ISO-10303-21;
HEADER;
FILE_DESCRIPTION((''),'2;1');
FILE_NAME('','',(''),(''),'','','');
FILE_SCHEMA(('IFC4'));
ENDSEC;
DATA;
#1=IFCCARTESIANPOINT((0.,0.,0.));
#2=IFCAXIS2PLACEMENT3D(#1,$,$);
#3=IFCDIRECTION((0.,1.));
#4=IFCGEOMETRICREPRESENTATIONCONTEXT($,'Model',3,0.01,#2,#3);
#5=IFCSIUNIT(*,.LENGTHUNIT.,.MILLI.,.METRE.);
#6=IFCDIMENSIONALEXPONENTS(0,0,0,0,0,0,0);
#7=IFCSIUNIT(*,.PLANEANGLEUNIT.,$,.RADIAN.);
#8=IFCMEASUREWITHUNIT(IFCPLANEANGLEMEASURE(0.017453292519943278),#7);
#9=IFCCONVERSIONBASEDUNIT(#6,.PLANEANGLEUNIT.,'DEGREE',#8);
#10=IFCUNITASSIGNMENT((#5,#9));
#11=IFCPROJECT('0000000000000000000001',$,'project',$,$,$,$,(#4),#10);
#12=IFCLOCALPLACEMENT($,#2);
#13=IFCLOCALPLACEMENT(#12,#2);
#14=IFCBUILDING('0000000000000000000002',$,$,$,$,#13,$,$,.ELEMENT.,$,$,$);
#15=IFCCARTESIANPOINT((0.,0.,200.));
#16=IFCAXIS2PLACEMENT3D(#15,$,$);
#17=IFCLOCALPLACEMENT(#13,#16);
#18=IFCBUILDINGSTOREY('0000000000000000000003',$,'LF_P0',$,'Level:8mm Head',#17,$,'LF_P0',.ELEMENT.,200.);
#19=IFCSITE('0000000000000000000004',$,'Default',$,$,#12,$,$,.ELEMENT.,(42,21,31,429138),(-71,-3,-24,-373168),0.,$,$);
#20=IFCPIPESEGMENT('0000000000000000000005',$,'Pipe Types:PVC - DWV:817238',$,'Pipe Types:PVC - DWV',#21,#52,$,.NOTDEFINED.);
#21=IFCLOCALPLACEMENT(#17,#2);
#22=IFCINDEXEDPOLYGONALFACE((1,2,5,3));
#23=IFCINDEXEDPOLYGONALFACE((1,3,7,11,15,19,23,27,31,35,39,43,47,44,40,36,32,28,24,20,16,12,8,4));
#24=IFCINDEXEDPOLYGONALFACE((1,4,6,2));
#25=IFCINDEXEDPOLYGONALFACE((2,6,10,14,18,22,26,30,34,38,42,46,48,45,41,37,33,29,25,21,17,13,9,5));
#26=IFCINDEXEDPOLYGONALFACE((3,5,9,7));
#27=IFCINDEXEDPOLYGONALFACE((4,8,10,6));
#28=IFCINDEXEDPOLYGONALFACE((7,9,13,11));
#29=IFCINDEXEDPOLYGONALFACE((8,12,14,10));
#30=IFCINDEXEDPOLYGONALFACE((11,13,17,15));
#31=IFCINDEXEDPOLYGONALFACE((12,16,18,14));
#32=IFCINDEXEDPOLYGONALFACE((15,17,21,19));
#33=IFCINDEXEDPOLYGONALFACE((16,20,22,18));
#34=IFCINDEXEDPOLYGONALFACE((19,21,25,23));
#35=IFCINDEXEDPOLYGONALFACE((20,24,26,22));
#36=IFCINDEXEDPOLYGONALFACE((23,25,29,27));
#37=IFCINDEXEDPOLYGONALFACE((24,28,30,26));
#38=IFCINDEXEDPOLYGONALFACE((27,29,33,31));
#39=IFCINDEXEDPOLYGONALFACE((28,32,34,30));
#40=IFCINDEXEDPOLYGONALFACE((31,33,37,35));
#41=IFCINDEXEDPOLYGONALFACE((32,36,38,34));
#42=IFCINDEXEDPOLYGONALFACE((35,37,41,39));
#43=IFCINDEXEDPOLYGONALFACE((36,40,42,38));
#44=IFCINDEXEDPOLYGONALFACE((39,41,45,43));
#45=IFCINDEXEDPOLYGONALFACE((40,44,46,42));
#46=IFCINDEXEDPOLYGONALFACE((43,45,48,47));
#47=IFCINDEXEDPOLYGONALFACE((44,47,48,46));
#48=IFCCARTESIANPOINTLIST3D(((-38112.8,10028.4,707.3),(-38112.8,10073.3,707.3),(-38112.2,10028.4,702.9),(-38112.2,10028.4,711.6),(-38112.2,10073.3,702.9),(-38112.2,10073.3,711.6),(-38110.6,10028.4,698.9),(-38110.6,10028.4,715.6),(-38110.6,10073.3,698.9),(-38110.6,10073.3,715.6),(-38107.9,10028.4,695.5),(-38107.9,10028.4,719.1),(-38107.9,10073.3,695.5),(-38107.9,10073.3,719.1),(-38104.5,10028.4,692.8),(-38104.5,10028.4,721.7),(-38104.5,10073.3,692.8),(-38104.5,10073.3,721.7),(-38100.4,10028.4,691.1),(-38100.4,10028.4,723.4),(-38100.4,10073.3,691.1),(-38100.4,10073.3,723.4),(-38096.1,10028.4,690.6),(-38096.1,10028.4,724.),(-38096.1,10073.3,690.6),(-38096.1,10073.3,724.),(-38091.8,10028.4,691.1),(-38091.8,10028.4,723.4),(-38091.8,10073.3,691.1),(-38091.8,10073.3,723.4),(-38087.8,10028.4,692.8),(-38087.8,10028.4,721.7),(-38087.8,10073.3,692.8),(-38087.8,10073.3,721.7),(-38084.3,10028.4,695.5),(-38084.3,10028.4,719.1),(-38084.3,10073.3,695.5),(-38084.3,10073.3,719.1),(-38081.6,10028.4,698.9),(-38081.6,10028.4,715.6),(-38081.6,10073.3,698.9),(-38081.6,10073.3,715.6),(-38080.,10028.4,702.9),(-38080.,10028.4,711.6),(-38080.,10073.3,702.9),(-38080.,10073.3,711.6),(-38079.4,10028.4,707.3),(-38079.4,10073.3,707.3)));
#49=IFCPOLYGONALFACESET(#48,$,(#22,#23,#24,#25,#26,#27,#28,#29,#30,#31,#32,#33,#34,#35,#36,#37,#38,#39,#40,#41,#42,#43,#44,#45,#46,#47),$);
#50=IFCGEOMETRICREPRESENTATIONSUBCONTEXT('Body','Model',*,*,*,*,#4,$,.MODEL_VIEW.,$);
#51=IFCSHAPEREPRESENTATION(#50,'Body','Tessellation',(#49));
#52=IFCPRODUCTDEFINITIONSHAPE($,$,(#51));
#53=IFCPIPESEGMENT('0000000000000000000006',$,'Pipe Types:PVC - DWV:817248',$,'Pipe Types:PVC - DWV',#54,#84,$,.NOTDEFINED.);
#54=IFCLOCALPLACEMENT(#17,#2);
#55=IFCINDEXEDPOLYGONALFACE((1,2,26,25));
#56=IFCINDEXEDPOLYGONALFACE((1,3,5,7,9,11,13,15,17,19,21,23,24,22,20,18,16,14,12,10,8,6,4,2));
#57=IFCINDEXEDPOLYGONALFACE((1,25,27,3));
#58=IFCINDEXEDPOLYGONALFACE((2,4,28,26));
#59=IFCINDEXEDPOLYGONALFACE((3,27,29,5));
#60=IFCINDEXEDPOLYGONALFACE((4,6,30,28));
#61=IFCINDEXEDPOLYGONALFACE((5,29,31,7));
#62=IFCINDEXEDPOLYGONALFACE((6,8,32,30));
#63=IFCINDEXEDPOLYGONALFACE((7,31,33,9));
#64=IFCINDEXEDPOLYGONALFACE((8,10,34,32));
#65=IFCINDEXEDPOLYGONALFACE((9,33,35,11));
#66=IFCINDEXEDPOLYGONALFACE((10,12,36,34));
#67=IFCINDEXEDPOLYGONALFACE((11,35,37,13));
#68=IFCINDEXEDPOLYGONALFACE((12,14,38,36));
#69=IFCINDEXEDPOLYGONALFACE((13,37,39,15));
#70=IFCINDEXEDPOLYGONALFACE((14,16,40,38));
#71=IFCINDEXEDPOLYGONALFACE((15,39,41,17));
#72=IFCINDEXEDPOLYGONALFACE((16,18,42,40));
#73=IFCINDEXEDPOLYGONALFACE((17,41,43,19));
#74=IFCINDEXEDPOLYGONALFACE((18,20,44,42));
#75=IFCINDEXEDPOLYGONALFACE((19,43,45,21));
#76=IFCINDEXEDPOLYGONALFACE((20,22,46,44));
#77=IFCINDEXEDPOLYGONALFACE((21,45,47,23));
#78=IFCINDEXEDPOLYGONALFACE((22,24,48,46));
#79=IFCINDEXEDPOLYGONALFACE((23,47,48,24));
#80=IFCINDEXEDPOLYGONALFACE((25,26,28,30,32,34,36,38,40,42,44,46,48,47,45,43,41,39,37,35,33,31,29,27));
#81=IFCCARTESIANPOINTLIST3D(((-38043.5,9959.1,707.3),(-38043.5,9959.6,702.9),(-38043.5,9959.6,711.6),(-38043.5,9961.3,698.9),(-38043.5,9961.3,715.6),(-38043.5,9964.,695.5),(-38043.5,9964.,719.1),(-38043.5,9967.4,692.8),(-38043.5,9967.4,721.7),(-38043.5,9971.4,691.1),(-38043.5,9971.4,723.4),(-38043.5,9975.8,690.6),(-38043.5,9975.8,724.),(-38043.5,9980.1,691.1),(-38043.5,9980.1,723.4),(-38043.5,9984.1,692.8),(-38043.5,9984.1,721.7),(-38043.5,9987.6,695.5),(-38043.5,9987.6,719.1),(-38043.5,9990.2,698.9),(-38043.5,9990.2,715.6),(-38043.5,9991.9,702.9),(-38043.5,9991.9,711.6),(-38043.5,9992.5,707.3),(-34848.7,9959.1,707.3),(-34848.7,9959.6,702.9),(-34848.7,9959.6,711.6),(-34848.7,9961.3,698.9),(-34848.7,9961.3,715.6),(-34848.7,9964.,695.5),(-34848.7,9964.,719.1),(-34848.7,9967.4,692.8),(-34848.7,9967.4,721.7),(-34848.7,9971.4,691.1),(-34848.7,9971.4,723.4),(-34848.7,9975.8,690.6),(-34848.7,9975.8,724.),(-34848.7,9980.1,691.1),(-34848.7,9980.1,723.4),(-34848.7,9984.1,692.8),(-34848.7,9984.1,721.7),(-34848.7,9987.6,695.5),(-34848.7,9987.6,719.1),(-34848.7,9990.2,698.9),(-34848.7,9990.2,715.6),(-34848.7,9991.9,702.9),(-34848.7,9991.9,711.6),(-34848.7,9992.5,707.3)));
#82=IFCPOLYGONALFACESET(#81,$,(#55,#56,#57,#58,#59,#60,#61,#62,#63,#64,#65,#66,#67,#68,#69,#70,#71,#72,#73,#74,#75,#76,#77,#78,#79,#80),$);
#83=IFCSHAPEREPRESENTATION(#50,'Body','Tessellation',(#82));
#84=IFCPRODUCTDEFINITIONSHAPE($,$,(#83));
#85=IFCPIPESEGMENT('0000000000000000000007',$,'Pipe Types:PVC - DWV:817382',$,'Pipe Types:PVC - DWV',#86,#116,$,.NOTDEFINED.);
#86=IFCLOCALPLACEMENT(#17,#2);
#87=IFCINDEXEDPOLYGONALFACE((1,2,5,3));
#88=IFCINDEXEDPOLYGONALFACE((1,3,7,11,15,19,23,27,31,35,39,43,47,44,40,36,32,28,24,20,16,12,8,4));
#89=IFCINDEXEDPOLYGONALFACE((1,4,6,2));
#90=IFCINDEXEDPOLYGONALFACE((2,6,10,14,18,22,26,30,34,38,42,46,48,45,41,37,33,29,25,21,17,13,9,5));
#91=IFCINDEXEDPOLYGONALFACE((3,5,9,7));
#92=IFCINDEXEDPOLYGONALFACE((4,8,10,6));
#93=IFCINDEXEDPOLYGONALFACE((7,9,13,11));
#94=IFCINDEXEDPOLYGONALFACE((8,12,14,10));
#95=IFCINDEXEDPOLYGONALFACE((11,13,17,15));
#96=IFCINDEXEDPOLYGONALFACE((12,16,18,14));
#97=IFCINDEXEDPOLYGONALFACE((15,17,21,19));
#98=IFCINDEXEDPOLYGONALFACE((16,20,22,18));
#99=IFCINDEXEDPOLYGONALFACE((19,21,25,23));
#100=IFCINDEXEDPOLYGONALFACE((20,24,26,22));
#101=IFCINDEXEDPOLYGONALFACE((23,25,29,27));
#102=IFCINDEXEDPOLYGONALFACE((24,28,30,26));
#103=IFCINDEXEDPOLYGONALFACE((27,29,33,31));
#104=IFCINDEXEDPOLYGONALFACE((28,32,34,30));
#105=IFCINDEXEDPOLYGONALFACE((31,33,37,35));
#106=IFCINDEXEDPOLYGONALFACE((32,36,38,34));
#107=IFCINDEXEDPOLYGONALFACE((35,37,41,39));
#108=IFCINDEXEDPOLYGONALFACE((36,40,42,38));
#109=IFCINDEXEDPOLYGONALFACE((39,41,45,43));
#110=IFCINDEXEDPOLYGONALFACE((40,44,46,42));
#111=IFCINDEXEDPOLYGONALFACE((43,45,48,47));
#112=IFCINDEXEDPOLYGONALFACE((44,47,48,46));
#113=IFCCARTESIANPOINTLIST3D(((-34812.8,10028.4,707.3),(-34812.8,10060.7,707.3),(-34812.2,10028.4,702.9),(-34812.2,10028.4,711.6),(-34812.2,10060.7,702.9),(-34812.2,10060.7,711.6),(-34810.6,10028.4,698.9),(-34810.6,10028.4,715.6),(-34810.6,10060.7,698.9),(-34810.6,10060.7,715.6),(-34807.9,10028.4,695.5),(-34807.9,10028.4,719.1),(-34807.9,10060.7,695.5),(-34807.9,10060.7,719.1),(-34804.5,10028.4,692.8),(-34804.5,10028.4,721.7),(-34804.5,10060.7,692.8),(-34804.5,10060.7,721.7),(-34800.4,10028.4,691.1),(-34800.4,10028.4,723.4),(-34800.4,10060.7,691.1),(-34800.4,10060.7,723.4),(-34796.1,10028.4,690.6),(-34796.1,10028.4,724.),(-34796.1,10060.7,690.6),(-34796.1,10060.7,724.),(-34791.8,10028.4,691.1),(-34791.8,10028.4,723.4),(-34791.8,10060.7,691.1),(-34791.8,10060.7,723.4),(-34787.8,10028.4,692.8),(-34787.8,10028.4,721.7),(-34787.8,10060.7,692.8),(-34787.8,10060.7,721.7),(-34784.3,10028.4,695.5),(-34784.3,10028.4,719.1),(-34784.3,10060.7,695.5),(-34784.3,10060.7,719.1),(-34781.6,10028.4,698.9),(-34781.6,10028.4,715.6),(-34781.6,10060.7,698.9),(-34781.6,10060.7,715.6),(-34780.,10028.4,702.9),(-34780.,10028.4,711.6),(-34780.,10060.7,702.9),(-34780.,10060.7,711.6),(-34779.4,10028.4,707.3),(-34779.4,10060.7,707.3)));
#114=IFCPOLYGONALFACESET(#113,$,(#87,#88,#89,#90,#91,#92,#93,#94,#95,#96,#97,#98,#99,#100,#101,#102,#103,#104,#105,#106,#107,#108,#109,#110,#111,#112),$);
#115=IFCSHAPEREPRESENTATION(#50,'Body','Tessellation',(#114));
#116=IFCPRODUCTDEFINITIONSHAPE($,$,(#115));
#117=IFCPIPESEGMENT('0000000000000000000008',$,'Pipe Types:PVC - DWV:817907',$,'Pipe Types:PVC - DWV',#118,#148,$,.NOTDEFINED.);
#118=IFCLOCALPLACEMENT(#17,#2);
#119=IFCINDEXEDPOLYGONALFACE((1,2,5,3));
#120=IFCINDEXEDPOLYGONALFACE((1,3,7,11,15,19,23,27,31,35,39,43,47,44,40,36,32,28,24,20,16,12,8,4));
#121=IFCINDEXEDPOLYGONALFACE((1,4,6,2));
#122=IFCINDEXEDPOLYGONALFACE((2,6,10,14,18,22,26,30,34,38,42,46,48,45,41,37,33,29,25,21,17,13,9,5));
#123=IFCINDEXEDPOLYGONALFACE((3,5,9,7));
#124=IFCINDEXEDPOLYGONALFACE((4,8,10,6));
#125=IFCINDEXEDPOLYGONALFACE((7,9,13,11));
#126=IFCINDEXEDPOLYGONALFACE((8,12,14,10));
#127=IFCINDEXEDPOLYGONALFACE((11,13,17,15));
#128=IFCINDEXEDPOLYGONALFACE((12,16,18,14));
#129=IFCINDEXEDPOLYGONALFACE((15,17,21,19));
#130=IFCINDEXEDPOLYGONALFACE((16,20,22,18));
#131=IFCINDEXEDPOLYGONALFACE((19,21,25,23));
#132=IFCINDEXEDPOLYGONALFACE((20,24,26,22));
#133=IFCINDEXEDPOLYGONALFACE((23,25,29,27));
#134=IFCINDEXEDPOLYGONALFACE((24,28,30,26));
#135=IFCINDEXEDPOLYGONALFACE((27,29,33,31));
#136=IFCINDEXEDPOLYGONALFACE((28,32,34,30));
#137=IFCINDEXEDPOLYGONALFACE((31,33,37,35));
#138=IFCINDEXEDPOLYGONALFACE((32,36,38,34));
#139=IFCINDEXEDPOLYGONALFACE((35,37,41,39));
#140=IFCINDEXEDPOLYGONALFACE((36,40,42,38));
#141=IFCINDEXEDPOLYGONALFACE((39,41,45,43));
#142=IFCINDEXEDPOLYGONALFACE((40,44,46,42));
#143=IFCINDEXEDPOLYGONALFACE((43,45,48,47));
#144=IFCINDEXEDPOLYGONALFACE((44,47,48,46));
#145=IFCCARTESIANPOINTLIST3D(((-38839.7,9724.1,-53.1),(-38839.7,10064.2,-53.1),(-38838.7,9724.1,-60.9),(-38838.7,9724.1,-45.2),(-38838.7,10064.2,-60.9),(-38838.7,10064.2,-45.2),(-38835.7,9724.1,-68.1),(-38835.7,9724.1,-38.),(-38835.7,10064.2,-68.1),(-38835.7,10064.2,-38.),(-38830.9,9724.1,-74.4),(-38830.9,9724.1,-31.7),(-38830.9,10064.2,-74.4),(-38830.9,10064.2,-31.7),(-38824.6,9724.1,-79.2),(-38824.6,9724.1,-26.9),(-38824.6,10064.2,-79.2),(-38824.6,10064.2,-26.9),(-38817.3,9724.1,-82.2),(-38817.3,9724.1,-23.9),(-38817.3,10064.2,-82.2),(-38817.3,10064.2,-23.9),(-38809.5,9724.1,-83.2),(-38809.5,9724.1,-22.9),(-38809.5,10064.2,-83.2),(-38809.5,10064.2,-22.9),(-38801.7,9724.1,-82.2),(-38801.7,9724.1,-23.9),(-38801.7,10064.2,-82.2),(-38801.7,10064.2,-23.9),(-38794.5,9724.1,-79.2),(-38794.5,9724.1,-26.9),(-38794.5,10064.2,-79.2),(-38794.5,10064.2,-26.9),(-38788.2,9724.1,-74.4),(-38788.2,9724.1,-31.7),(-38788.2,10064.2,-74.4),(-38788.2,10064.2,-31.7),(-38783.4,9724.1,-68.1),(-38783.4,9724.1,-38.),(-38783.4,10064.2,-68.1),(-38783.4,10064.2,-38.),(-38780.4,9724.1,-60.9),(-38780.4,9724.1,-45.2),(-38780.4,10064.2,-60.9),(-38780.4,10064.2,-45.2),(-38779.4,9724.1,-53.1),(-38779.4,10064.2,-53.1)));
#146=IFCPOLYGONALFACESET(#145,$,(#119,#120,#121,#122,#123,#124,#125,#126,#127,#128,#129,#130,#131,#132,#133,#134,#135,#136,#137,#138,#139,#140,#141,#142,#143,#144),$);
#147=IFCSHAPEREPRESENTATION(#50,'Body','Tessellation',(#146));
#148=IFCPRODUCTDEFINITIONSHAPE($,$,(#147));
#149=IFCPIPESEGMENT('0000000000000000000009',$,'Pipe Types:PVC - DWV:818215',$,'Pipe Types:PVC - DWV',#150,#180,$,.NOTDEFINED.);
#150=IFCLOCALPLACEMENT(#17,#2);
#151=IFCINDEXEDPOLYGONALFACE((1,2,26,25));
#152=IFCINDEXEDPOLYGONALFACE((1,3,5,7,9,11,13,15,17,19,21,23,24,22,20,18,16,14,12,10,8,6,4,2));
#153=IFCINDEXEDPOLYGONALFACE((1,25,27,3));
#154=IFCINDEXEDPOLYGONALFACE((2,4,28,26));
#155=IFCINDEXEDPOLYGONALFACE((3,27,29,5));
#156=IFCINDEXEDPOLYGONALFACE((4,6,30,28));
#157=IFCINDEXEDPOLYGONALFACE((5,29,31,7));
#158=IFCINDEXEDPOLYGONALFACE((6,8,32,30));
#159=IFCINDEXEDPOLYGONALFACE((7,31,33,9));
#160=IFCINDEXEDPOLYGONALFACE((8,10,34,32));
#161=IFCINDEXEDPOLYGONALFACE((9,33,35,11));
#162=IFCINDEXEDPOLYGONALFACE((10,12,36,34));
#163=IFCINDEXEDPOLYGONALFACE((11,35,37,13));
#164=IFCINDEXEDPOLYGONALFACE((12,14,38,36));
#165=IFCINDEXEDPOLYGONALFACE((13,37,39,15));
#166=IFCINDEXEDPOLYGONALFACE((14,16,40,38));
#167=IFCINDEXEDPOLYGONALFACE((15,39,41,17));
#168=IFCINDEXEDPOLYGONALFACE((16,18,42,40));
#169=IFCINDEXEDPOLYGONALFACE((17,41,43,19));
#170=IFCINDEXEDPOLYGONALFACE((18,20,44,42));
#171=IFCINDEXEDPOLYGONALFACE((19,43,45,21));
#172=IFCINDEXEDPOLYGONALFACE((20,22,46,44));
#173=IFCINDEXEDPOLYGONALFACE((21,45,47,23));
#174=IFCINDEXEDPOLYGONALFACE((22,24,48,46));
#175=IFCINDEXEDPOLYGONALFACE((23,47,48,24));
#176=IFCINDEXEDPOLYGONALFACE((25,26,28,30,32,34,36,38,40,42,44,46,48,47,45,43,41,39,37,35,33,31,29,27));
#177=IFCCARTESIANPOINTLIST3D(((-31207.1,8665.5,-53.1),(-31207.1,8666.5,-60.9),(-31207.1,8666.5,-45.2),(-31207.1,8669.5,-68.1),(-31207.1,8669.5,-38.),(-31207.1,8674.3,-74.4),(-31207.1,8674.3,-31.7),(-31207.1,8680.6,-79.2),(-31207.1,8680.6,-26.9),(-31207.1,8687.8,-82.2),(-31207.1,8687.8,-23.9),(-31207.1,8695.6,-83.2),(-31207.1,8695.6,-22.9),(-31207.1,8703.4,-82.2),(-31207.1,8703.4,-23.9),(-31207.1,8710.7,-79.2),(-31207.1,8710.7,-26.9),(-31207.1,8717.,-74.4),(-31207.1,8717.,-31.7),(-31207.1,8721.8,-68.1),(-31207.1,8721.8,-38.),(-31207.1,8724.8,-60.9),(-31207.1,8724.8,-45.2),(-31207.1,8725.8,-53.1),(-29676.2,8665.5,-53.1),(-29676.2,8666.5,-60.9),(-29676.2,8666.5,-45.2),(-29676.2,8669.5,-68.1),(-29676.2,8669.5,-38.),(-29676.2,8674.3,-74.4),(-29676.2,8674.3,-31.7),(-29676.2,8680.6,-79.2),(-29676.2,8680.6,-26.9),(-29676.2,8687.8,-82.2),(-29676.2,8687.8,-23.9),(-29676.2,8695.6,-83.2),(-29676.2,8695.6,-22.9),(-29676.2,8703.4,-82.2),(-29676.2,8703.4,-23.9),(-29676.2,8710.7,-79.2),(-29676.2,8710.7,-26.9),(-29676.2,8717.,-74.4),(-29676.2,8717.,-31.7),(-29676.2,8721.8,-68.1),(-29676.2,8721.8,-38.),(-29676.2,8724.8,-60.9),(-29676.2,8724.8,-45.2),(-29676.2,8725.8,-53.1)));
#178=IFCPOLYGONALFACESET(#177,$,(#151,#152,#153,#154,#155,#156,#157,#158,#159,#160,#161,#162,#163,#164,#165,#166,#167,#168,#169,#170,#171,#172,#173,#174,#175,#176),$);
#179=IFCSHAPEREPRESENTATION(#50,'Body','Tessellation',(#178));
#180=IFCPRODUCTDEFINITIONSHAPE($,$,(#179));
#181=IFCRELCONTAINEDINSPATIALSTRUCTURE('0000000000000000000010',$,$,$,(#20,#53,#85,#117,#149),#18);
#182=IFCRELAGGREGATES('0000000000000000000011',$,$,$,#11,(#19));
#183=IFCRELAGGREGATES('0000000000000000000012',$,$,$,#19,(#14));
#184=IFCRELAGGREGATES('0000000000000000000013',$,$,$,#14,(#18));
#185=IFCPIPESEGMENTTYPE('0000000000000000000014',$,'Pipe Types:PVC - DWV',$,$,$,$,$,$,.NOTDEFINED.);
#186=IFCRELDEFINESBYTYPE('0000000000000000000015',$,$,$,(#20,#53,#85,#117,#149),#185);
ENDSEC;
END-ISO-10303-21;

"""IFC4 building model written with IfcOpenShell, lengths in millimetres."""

from ifc_helpers import new_model, entity, si_unit, converted_unit, direction, frame, origin, place, context, subcontext, project, spatial, arc, indexed_curve, outline, extrude, type_object, element, save


model = new_model("IFC4")

# Units and contexts
model_context = context("Model", 3, precision=0.01, world=origin(), true_north=direction((0.0, 1.0)))
body_context = subcontext(model_context, "Body", "Model", "MODEL_VIEW")
ifc_project = project(units=[si_unit("LENGTHUNIT", "METRE", prefix="MILLI"), converted_unit("PLANEANGLEUNIT", "DEGREE", entity("IfcPlaneAngleMeasure", 0.017453292519943278), si_unit("PLANEANGLEUNIT", "RADIAN"), dimensions=[0, 0, 0, 0, 0, 0, 0])], contexts=[model_context])

# Site, building, storey
site_placement = place(None, origin())
site = spatial("IfcSite", under=ifc_project, at=site_placement, Name="Default", CompositionType="ELEMENT", RefLatitude=(42, 21, 31, 429138), RefLongitude=(-71, -3, -24, -373168), RefElevation=0.0)
building_placement = place(site_placement, origin())
building = spatial("IfcBuilding", under=site, at=building_placement, CompositionType="ELEMENT")
storey_placement = place(building_placement, frame((0.0, 0.0, 200.0)))
storey = spatial("IfcBuildingStorey", under=building, at=storey_placement, Name="LF_P0", ObjectType="Level:8mm Head", LongName="LF_P0", CompositionType="ELEMENT", Elevation=200.0)

# Pipe segments
pipe_segment_type_1 = type_object("IfcPipeSegmentType", Name="Pipe Types:PVC - DWV", PredefinedType="NOTDEFINED")
pipe_segment_1_placement = place(storey_placement, origin())
element("IfcPipeSegment", 1, at=pipe_segment_1_placement, inside=storey, type_object=pipe_segment_type_1, Name="Pipe Types:PVC - DWV:817238", ObjectType="Pipe Types:PVC - DWV", PredefinedType="NOTDEFINED", context=body_context, shape_type="SweptSolid", body=[
    extrude(outline(indexed_curve([(16.7, 0.0), (11.8, 11.8), (0.0, 16.7), (-11.8, 11.8), (-16.7, 0.0), (-11.8, -11.8), (0.0, -16.7), (11.8, -11.8)], segments=[arc(1, 2, 3), arc(3, 4, 5), arc(5, 6, 7), arc(7, 8, 1)], self_intersect=False)), frame((-38096.1, 10028.4, 707.3), z_axis=(0.0, 1.0, 0.0), x_axis=(-1.0, 0.0, 0.0)), (0.0, 0.0, 1.0), 44.9),
])
pipe_segment_2_placement = place(storey_placement, origin())
element("IfcPipeSegment", 2, at=pipe_segment_2_placement, inside=storey, type_object=pipe_segment_type_1, Name="Pipe Types:PVC - DWV:817248", ObjectType="Pipe Types:PVC - DWV", PredefinedType="NOTDEFINED", context=body_context, shape_type="SweptSolid", body=[
    extrude(outline(indexed_curve([(16.7, 0.0), (11.8, 11.8), (0.0, 16.7), (-11.8, 11.8), (-16.7, 0.0), (-11.8, -11.8), (0.0, -16.7), (11.8, -11.8)], segments=[arc(1, 2, 3), arc(3, 4, 5), arc(5, 6, 7), arc(7, 8, 1)], self_intersect=False)), frame((-38043.5, 9975.8, 707.3), z_axis=(1.0, 0.0, 0.0), x_axis=(0.0, -1.0, 0.0)), (0.0, 0.0, 1.0), 3194.8),
])
pipe_segment_3_placement = place(storey_placement, origin())
element("IfcPipeSegment", 3, at=pipe_segment_3_placement, inside=storey, type_object=pipe_segment_type_1, Name="Pipe Types:PVC - DWV:817382", ObjectType="Pipe Types:PVC - DWV", PredefinedType="NOTDEFINED", context=body_context, shape_type="SweptSolid", body=[
    extrude(outline(indexed_curve([(16.7, 0.0), (11.8, 11.8), (0.0, 16.7), (-11.8, 11.8), (-16.7, 0.0), (-11.8, -11.8), (0.0, -16.7), (11.8, -11.8)], segments=[arc(1, 2, 3), arc(3, 4, 5), arc(5, 6, 7), arc(7, 8, 1)], self_intersect=False)), frame((-34796.1, 10028.4, 707.3), z_axis=(0.0, 1.0, 0.0), x_axis=(-1.0, 0.0, 0.0)), (0.0, 0.0, 1.0), 32.3),
])
pipe_segment_4_placement = place(storey_placement, origin())
element("IfcPipeSegment", 4, at=pipe_segment_4_placement, inside=storey, type_object=pipe_segment_type_1, Name="Pipe Types:PVC - DWV:817907", ObjectType="Pipe Types:PVC - DWV", PredefinedType="NOTDEFINED", context=body_context, shape_type="SweptSolid", body=[
    extrude(outline(indexed_curve([(30.2, 0.0), (21.3, 21.3), (0.0, 30.2), (-21.3, 21.3), (-30.2, 0.0), (-21.3, -21.3), (0.0, -30.2), (21.3, -21.3)], segments=[arc(1, 2, 3), arc(3, 4, 5), arc(5, 6, 7), arc(7, 8, 1)], self_intersect=False)), frame((-38809.5, 9724.1, -53.1), z_axis=(0.0, 1.0, 0.0), x_axis=(-1.0, 0.0, 0.0)), (0.0, 0.0, 1.0), 340.1),
])
pipe_segment_5_placement = place(storey_placement, origin())
element("IfcPipeSegment", 5, at=pipe_segment_5_placement, inside=storey, type_object=pipe_segment_type_1, Name="Pipe Types:PVC - DWV:818215", ObjectType="Pipe Types:PVC - DWV", PredefinedType="NOTDEFINED", context=body_context, shape_type="SweptSolid", body=[
    extrude(outline(indexed_curve([(30.2, 0.0), (21.3, 21.3), (0.0, 30.2), (-21.3, 21.3), (-30.2, 0.0), (-21.3, -21.3), (0.0, -30.2), (21.3, -21.3)], segments=[arc(1, 2, 3), arc(3, 4, 5), arc(5, 6, 7), arc(7, 8, 1)], self_intersect=False)), frame((-31207.1, 8695.6, -53.1), z_axis=(1.0, 0.0, 0.0), x_axis=(0.0, -1.0, 0.0)), (0.0, 0.0, 1.0), 1530.9),
])

save(model, "model.ifc")
